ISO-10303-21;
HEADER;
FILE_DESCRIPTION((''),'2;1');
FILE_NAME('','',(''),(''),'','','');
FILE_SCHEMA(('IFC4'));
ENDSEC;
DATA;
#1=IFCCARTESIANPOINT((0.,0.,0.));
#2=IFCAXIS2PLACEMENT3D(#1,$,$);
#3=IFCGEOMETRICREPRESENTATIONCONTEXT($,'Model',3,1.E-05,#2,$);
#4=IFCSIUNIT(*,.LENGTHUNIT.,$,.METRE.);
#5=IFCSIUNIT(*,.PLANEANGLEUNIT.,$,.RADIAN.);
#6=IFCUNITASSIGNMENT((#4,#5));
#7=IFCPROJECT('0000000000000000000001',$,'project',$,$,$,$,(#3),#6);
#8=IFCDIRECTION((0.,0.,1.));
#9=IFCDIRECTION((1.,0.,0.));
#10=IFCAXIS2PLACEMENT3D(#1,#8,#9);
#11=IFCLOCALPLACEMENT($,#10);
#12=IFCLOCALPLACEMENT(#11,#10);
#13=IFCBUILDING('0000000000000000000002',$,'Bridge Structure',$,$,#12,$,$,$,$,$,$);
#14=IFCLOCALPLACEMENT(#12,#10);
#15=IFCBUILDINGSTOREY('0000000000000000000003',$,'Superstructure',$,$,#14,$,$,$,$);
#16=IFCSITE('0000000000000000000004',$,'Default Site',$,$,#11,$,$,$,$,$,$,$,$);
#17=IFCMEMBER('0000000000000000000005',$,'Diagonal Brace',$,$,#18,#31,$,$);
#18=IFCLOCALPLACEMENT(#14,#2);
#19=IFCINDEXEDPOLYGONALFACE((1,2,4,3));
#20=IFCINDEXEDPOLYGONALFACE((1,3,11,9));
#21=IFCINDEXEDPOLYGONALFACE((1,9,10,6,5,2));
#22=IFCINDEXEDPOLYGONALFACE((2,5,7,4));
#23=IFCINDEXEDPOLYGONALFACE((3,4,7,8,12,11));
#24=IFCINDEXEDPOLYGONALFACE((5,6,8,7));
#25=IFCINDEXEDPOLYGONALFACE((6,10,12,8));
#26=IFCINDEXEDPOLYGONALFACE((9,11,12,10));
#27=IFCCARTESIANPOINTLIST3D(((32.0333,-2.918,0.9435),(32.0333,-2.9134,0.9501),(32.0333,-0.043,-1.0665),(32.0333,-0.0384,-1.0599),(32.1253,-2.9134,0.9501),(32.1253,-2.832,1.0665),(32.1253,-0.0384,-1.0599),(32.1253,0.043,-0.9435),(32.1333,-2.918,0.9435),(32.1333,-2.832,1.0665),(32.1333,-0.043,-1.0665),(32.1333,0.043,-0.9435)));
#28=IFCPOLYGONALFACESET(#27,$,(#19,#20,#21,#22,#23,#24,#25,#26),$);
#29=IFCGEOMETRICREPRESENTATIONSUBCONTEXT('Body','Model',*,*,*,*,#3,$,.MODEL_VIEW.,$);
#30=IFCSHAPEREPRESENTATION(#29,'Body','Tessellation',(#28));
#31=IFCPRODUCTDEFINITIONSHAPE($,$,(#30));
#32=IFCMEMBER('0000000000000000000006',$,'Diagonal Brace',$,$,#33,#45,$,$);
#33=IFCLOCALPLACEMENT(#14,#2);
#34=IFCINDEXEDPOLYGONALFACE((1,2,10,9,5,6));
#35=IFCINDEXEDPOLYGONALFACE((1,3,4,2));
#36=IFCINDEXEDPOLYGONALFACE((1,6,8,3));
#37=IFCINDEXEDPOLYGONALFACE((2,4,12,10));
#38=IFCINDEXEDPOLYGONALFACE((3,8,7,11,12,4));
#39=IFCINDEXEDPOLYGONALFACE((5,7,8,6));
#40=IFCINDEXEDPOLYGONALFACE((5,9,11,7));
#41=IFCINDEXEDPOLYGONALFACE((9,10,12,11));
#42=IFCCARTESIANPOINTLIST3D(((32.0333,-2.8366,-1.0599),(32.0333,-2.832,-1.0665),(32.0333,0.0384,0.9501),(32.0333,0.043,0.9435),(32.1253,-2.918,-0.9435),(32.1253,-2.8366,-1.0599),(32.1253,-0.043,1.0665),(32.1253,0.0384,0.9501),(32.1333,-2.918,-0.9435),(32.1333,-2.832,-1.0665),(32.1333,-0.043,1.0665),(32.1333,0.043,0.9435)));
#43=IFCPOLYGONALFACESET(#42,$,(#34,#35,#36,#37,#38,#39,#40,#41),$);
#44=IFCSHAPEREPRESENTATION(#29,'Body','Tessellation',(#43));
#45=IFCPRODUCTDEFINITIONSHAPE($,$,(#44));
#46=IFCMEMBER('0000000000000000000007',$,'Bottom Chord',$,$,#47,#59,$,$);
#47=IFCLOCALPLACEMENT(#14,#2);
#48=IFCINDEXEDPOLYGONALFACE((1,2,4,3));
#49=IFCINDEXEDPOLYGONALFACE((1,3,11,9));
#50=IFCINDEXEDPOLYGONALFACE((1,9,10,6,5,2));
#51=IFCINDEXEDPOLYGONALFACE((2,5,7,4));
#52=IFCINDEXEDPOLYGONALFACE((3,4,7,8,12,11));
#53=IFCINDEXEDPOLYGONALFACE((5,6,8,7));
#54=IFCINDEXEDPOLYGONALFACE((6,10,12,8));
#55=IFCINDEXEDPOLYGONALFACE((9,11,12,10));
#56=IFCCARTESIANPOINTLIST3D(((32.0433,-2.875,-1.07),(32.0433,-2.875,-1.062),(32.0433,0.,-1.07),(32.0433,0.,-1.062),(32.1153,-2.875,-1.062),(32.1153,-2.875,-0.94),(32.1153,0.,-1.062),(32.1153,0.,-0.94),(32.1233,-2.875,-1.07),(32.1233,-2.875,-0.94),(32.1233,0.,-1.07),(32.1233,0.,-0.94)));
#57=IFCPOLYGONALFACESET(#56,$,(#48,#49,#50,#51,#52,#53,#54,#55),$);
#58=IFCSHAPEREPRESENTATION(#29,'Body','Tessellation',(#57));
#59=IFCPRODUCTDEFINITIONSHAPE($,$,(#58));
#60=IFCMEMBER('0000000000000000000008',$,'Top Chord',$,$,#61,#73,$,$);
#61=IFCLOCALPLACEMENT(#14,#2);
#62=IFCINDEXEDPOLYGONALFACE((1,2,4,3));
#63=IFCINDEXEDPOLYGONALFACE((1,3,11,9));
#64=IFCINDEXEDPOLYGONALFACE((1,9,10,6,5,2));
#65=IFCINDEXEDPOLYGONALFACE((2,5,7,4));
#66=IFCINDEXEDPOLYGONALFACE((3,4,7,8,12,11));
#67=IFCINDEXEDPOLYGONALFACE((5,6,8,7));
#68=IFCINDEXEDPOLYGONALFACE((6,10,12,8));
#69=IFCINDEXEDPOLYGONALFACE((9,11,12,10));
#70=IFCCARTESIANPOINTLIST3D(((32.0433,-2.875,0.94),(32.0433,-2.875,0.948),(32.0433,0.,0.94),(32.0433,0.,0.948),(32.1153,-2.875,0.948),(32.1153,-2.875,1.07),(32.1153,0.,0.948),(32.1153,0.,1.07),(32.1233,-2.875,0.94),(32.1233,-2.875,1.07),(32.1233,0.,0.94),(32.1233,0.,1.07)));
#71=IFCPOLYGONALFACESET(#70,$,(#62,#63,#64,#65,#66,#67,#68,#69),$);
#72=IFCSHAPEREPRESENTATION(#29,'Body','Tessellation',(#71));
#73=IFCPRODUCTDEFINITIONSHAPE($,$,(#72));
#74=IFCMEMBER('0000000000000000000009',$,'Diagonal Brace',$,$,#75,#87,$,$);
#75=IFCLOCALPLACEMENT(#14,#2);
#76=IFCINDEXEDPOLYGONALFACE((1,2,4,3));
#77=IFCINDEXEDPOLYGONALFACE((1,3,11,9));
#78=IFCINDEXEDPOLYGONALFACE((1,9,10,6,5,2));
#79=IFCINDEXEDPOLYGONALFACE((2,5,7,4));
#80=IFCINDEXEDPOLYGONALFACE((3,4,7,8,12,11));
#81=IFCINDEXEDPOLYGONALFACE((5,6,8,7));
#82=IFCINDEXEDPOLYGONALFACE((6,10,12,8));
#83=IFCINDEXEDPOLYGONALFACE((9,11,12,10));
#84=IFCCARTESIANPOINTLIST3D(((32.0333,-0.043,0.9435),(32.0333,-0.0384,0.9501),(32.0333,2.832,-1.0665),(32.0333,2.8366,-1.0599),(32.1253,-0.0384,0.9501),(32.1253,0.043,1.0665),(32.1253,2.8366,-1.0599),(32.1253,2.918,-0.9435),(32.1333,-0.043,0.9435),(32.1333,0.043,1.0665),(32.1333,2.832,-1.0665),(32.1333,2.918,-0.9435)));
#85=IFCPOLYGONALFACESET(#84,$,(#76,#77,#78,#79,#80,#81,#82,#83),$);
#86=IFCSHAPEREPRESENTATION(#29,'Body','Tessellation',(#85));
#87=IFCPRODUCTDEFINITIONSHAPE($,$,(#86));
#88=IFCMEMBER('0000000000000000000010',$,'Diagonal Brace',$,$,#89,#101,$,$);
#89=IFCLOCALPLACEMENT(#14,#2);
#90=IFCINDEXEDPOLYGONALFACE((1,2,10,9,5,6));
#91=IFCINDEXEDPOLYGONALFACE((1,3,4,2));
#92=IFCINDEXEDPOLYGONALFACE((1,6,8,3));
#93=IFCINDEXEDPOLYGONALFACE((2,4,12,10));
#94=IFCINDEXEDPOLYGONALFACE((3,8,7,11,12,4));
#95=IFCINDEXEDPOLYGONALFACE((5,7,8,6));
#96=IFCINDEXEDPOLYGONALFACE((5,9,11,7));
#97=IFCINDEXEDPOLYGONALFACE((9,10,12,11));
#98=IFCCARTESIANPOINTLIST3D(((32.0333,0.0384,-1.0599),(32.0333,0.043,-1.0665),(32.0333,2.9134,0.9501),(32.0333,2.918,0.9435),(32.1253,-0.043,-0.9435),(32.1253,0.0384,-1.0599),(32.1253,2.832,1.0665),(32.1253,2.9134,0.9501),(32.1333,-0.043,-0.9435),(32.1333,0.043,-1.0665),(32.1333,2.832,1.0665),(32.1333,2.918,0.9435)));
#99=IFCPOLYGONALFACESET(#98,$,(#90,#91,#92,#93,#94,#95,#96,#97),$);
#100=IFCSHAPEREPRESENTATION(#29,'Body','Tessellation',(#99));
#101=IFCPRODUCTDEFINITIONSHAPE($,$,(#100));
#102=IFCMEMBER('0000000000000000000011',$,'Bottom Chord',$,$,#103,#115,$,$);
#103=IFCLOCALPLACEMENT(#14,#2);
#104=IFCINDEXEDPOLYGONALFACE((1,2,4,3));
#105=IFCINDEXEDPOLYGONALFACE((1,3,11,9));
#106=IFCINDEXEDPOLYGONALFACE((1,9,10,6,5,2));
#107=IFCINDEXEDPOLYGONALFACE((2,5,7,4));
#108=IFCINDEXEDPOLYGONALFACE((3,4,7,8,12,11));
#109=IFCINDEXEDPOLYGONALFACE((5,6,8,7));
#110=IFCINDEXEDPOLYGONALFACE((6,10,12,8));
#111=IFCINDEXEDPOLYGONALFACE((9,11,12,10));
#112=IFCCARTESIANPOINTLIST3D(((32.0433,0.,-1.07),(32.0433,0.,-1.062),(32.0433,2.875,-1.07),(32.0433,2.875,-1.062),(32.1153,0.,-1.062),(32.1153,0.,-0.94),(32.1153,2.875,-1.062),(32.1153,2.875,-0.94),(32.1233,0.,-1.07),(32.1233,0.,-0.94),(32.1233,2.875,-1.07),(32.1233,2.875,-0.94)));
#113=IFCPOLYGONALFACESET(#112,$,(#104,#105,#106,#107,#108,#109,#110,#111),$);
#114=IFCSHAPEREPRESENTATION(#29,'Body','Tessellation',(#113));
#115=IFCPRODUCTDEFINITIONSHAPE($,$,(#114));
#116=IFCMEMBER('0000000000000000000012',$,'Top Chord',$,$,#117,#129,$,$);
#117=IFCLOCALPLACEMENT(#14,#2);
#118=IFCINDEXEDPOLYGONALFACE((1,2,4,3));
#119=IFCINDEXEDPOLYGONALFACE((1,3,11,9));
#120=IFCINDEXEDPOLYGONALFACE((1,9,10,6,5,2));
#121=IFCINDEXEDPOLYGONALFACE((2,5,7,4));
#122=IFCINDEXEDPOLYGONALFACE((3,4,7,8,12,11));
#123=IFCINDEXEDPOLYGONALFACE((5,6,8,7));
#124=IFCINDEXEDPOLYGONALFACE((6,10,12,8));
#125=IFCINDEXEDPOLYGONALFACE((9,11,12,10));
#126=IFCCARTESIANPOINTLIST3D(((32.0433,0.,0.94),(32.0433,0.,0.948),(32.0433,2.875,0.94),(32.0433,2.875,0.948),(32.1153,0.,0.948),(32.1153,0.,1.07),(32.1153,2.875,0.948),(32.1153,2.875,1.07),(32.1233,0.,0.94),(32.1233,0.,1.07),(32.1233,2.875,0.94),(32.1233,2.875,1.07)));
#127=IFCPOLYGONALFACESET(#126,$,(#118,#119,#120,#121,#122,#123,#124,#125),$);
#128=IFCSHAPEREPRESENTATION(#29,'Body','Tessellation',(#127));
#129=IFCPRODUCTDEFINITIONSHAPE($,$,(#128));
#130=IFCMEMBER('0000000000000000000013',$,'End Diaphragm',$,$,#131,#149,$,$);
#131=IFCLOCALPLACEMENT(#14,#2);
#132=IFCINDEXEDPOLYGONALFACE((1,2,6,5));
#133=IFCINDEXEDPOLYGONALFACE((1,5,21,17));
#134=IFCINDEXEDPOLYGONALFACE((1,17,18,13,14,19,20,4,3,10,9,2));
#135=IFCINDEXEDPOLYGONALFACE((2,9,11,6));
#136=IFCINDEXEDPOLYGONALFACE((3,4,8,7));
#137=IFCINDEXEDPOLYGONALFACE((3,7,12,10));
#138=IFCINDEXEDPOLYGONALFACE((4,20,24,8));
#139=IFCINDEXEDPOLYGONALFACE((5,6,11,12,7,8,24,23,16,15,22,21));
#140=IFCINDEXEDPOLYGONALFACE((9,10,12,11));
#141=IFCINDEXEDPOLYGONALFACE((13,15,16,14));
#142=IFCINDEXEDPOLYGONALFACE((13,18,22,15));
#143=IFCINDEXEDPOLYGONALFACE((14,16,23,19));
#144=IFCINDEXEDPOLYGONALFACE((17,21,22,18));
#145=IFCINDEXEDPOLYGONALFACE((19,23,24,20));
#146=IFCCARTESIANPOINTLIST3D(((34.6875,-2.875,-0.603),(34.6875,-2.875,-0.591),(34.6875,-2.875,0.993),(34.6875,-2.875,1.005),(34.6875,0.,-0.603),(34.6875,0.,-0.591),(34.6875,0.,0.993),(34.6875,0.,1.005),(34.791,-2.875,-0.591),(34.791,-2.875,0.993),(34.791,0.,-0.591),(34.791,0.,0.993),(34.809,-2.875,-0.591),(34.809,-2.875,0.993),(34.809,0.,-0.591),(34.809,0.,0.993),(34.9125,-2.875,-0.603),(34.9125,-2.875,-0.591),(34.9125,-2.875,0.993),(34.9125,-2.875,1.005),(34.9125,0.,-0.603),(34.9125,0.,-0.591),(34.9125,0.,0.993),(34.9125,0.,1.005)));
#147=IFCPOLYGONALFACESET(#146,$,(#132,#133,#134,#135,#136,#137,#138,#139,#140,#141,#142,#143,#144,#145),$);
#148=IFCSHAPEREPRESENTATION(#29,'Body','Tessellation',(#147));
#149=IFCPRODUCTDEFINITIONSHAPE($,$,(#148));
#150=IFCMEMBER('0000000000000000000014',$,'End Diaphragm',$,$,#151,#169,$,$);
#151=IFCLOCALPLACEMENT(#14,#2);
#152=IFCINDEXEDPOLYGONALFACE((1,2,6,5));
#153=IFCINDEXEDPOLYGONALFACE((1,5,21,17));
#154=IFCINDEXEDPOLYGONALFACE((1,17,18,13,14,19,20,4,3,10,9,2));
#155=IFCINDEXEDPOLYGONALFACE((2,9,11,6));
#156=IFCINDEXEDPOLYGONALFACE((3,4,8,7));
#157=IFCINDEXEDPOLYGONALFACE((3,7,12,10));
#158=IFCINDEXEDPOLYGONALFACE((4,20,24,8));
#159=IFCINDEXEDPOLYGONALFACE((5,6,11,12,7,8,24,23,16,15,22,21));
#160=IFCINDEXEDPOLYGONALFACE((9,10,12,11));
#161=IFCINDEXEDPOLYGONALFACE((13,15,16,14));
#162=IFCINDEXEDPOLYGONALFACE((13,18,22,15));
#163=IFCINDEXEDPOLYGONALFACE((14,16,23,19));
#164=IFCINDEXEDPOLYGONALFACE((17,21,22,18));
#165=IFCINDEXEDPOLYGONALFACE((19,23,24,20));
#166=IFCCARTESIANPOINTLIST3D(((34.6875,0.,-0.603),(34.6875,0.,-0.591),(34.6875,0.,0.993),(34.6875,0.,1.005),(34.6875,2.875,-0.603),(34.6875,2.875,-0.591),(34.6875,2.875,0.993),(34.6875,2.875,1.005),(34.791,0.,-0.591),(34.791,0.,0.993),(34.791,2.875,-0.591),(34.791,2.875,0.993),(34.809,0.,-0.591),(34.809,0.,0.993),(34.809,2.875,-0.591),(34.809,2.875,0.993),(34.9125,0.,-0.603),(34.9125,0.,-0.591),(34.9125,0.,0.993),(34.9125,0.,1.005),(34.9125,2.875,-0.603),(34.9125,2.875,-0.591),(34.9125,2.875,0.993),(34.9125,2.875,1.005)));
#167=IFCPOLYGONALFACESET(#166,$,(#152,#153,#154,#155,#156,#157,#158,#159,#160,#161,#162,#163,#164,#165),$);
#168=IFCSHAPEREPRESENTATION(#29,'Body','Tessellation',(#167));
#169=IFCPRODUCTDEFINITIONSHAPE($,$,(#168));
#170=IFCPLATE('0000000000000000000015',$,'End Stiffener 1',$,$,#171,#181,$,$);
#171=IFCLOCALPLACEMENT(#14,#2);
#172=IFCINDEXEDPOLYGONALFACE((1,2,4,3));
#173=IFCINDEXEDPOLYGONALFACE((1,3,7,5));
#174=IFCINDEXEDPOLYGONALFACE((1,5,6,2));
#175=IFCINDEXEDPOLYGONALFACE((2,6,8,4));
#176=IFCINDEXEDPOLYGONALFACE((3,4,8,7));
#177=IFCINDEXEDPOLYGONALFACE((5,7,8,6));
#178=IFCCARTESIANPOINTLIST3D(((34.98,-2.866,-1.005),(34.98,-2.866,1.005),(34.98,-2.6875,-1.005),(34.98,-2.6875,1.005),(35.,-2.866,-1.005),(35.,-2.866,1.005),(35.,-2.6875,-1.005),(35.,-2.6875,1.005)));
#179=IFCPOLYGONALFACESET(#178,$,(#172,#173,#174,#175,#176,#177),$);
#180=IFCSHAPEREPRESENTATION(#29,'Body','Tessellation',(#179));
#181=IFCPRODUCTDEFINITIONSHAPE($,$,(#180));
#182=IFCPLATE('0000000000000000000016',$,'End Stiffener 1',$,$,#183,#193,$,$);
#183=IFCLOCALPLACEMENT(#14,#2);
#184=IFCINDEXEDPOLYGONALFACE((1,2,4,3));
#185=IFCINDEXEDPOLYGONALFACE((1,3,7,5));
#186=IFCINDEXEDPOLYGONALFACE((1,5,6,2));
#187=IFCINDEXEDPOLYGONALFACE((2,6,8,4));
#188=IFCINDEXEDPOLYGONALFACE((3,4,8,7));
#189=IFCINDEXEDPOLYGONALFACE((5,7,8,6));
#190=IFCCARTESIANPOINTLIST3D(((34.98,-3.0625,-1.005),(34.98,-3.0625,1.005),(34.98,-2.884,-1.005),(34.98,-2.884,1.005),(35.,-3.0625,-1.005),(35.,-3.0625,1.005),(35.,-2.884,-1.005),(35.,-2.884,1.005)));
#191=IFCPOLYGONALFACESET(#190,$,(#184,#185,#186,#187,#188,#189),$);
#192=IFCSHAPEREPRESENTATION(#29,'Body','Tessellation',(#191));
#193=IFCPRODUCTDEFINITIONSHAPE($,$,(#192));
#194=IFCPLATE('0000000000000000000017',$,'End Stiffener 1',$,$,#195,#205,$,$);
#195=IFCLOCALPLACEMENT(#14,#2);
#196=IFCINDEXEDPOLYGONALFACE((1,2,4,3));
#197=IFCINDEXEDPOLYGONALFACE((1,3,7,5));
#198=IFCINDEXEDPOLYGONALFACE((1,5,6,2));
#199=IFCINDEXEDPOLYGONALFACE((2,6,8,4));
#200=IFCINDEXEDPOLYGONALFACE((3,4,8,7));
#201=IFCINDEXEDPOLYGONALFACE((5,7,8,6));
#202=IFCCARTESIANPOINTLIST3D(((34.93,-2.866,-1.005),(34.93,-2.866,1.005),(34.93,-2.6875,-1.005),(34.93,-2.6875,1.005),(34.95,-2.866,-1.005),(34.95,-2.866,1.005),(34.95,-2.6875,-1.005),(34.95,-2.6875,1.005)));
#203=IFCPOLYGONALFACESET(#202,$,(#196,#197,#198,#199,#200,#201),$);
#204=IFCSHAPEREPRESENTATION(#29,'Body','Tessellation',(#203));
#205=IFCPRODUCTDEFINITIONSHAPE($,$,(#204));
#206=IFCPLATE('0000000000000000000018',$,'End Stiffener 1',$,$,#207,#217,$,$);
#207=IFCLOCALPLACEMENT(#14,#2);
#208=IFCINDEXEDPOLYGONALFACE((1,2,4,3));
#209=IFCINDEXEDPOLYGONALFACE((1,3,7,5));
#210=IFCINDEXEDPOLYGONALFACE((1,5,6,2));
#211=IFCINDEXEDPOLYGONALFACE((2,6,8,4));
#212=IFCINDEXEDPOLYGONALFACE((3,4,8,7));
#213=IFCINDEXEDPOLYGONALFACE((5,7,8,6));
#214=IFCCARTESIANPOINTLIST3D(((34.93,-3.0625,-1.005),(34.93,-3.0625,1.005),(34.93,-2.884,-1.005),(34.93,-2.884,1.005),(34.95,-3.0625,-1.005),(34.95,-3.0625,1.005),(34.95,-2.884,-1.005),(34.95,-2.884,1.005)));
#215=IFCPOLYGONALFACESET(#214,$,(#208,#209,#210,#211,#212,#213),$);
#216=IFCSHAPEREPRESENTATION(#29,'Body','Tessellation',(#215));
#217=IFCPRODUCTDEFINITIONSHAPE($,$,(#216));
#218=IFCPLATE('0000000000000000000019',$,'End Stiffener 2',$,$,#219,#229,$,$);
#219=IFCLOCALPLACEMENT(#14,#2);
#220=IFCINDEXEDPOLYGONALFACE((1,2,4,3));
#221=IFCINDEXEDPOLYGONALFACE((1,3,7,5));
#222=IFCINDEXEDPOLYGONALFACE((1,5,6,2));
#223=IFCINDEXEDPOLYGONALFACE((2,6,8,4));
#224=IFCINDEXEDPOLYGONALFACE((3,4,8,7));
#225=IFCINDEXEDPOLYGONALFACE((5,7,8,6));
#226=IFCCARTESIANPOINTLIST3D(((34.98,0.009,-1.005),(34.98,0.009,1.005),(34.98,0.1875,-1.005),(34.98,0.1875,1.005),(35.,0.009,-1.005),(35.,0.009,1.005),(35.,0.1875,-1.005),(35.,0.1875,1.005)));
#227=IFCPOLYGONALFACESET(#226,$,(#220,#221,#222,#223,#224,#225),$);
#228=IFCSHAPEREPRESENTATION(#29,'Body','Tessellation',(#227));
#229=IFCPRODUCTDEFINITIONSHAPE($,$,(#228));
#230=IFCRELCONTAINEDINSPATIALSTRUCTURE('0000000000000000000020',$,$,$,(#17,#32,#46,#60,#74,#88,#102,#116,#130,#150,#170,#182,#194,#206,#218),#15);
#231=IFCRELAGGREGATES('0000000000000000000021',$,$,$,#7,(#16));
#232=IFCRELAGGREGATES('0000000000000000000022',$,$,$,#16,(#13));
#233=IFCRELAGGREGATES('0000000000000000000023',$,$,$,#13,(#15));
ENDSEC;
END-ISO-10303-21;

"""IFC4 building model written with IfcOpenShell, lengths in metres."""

from ifc_helpers import new_model, si_unit, frame, origin, origin_with_axes, origin_2d_with_axis, place, context, subcontext, project, spatial, rectangle, i_section, l_section, extrude, element, save


model = new_model("IFC4")

# Units and contexts
model_context = context("Model", 3, precision=1e-05, world=origin())
body_context = subcontext(model_context, "Body", "Model", "MODEL_VIEW")
ifc_project = project(units=[si_unit("LENGTHUNIT", "METRE"), si_unit("PLANEANGLEUNIT", "RADIAN")], contexts=[model_context])

# Site, building, storey
site_placement = place(None, origin_with_axes())
site = spatial("IfcSite", under=ifc_project, at=site_placement, Name="Default Site")
building_placement = place(site_placement, origin_with_axes())
building = spatial("IfcBuilding", under=site, at=building_placement, Name="Bridge Structure")
storey_placement = place(building_placement, origin_with_axes())
storey = spatial("IfcBuildingStorey", under=building, at=storey_placement, Name="Superstructure")

# Members
for number, where, z_axis, x_axis, name in (
    (1, (32.0833, -2.875, 1.005), (0.0, 0.819567, -0.572984), (-1.0, 0.0, 0.0), "Diagonal Brace"),
    (2, (32.0833, -2.875, -1.005), (0.0, 0.819567, 0.572984), (-1.0, 0.0, 0.0), "Diagonal Brace"),
):
    element("IfcMember", number, at=place(storey_placement, frame(where, z_axis=z_axis, x_axis=x_axis)), inside=storey, Name=name, context=body_context, shape_type="SweptSolid", body=[
        extrude(l_section(Depth=0.15, Width=0.1, Thickness=0.008, at=origin_2d_with_axis()), origin_with_axes(), (0.0, 0.0, 1.0), 3.508),
    ])
for number, where, z_axis, x_axis, name in (
    (3, (32.0833, -2.875, -1.005), (0.0, 1.0, 0.0), (-1.0, 0.0, 0.0), "Bottom Chord"),
    (4, (32.0833, -2.875, 1.005), (0.0, 1.0, 0.0), (-1.0, 0.0, 0.0), "Top Chord"),
):
    element("IfcMember", number, at=place(storey_placement, frame(where, z_axis=z_axis, x_axis=x_axis)), inside=storey, Name=name, context=body_context, shape_type="SweptSolid", body=[
        extrude(l_section(Depth=0.13, Width=0.08, Thickness=0.008, at=origin_2d_with_axis()), origin_with_axes(), (0.0, 0.0, 1.0), 2.875),
    ])
for number, where, z_axis, x_axis, name in (
    (5, (32.0833, 0.0, 1.005), (0.0, 0.819567, -0.572984), (-1.0, 0.0, 0.0), "Diagonal Brace"),
    (6, (32.0833, 0.0, -1.005), (0.0, 0.819567, 0.572984), (-1.0, 0.0, 0.0), "Diagonal Brace"),
):
    element("IfcMember", number, at=place(storey_placement, frame(where, z_axis=z_axis, x_axis=x_axis)), inside=storey, Name=name, context=body_context, shape_type="SweptSolid", body=[
        extrude(l_section(Depth=0.15, Width=0.1, Thickness=0.008, at=origin_2d_with_axis()), origin_with_axes(), (0.0, 0.0, 1.0), 3.508),
    ])
for number, where, z_axis, x_axis, name in (
    (7, (32.0833, 0.0, -1.005), (0.0, 1.0, 0.0), (-1.0, 0.0, 0.0), "Bottom Chord"),
    (8, (32.0833, 0.0, 1.005), (0.0, 1.0, 0.0), (-1.0, 0.0, 0.0), "Top Chord"),
):
    element("IfcMember", number, at=place(storey_placement, frame(where, z_axis=z_axis, x_axis=x_axis)), inside=storey, Name=name, context=body_context, shape_type="SweptSolid", body=[
        extrude(l_section(Depth=0.13, Width=0.08, Thickness=0.008, at=origin_2d_with_axis()), origin_with_axes(), (0.0, 0.0, 1.0), 2.875),
    ])
for number, where, z_axis, x_axis, name in (
    (9, (34.8, -2.875, 0.201), (0.0, 1.0, 0.0), (-1.0, 0.0, 0.0), "End Diaphragm"),
    (10, (34.8, 0.0, 0.201), (0.0, 1.0, 0.0), (-1.0, 0.0, 0.0), "End Diaphragm"),
):
    element("IfcMember", number, at=place(storey_placement, frame(where, z_axis=z_axis, x_axis=x_axis)), inside=storey, Name=name, context=body_context, shape_type="SweptSolid", body=[
        extrude(i_section(OverallWidth=0.225, OverallDepth=1.608, WebThickness=0.018, FlangeThickness=0.012, at=origin_2d_with_axis()), origin_with_axes(), (0.0, 0.0, 1.0), 2.875),
    ])

# Plates
for number, where, z_axis, x_axis, name in (
    (11, (34.99, -2.7768, -1.005), (0.0, 0.0, 1.0), (1.0, 0.0, 0.0), "End Stiffener 1"),
    (12, (34.99, -2.9733, -1.005), (0.0, 0.0, 1.0), (1.0, 0.0, 0.0), "End Stiffener 1"),
    (13, (34.94, -2.7768, -1.005), (0.0, 0.0, 1.0), (1.0, 0.0, 0.0), "End Stiffener 1"),
    (14, (34.94, -2.9733, -1.005), (0.0, 0.0, 1.0), (1.0, 0.0, 0.0), "End Stiffener 1"),
    (15, (34.99, 0.0983, -1.005), (0.0, 0.0, 1.0), (1.0, 0.0, 0.0), "End Stiffener 2"),
):
    element("IfcPlate", number, at=place(storey_placement, frame(where, z_axis=z_axis, x_axis=x_axis)), inside=storey, Name=name, context=body_context, shape_type="SweptSolid", body=[
        extrude(rectangle(XDim=0.02, YDim=0.1785, at=origin_2d_with_axis()), origin_with_axes(), (0.0, 0.0, 1.0), 2.01),
    ])

save(model, "model.ifc")
